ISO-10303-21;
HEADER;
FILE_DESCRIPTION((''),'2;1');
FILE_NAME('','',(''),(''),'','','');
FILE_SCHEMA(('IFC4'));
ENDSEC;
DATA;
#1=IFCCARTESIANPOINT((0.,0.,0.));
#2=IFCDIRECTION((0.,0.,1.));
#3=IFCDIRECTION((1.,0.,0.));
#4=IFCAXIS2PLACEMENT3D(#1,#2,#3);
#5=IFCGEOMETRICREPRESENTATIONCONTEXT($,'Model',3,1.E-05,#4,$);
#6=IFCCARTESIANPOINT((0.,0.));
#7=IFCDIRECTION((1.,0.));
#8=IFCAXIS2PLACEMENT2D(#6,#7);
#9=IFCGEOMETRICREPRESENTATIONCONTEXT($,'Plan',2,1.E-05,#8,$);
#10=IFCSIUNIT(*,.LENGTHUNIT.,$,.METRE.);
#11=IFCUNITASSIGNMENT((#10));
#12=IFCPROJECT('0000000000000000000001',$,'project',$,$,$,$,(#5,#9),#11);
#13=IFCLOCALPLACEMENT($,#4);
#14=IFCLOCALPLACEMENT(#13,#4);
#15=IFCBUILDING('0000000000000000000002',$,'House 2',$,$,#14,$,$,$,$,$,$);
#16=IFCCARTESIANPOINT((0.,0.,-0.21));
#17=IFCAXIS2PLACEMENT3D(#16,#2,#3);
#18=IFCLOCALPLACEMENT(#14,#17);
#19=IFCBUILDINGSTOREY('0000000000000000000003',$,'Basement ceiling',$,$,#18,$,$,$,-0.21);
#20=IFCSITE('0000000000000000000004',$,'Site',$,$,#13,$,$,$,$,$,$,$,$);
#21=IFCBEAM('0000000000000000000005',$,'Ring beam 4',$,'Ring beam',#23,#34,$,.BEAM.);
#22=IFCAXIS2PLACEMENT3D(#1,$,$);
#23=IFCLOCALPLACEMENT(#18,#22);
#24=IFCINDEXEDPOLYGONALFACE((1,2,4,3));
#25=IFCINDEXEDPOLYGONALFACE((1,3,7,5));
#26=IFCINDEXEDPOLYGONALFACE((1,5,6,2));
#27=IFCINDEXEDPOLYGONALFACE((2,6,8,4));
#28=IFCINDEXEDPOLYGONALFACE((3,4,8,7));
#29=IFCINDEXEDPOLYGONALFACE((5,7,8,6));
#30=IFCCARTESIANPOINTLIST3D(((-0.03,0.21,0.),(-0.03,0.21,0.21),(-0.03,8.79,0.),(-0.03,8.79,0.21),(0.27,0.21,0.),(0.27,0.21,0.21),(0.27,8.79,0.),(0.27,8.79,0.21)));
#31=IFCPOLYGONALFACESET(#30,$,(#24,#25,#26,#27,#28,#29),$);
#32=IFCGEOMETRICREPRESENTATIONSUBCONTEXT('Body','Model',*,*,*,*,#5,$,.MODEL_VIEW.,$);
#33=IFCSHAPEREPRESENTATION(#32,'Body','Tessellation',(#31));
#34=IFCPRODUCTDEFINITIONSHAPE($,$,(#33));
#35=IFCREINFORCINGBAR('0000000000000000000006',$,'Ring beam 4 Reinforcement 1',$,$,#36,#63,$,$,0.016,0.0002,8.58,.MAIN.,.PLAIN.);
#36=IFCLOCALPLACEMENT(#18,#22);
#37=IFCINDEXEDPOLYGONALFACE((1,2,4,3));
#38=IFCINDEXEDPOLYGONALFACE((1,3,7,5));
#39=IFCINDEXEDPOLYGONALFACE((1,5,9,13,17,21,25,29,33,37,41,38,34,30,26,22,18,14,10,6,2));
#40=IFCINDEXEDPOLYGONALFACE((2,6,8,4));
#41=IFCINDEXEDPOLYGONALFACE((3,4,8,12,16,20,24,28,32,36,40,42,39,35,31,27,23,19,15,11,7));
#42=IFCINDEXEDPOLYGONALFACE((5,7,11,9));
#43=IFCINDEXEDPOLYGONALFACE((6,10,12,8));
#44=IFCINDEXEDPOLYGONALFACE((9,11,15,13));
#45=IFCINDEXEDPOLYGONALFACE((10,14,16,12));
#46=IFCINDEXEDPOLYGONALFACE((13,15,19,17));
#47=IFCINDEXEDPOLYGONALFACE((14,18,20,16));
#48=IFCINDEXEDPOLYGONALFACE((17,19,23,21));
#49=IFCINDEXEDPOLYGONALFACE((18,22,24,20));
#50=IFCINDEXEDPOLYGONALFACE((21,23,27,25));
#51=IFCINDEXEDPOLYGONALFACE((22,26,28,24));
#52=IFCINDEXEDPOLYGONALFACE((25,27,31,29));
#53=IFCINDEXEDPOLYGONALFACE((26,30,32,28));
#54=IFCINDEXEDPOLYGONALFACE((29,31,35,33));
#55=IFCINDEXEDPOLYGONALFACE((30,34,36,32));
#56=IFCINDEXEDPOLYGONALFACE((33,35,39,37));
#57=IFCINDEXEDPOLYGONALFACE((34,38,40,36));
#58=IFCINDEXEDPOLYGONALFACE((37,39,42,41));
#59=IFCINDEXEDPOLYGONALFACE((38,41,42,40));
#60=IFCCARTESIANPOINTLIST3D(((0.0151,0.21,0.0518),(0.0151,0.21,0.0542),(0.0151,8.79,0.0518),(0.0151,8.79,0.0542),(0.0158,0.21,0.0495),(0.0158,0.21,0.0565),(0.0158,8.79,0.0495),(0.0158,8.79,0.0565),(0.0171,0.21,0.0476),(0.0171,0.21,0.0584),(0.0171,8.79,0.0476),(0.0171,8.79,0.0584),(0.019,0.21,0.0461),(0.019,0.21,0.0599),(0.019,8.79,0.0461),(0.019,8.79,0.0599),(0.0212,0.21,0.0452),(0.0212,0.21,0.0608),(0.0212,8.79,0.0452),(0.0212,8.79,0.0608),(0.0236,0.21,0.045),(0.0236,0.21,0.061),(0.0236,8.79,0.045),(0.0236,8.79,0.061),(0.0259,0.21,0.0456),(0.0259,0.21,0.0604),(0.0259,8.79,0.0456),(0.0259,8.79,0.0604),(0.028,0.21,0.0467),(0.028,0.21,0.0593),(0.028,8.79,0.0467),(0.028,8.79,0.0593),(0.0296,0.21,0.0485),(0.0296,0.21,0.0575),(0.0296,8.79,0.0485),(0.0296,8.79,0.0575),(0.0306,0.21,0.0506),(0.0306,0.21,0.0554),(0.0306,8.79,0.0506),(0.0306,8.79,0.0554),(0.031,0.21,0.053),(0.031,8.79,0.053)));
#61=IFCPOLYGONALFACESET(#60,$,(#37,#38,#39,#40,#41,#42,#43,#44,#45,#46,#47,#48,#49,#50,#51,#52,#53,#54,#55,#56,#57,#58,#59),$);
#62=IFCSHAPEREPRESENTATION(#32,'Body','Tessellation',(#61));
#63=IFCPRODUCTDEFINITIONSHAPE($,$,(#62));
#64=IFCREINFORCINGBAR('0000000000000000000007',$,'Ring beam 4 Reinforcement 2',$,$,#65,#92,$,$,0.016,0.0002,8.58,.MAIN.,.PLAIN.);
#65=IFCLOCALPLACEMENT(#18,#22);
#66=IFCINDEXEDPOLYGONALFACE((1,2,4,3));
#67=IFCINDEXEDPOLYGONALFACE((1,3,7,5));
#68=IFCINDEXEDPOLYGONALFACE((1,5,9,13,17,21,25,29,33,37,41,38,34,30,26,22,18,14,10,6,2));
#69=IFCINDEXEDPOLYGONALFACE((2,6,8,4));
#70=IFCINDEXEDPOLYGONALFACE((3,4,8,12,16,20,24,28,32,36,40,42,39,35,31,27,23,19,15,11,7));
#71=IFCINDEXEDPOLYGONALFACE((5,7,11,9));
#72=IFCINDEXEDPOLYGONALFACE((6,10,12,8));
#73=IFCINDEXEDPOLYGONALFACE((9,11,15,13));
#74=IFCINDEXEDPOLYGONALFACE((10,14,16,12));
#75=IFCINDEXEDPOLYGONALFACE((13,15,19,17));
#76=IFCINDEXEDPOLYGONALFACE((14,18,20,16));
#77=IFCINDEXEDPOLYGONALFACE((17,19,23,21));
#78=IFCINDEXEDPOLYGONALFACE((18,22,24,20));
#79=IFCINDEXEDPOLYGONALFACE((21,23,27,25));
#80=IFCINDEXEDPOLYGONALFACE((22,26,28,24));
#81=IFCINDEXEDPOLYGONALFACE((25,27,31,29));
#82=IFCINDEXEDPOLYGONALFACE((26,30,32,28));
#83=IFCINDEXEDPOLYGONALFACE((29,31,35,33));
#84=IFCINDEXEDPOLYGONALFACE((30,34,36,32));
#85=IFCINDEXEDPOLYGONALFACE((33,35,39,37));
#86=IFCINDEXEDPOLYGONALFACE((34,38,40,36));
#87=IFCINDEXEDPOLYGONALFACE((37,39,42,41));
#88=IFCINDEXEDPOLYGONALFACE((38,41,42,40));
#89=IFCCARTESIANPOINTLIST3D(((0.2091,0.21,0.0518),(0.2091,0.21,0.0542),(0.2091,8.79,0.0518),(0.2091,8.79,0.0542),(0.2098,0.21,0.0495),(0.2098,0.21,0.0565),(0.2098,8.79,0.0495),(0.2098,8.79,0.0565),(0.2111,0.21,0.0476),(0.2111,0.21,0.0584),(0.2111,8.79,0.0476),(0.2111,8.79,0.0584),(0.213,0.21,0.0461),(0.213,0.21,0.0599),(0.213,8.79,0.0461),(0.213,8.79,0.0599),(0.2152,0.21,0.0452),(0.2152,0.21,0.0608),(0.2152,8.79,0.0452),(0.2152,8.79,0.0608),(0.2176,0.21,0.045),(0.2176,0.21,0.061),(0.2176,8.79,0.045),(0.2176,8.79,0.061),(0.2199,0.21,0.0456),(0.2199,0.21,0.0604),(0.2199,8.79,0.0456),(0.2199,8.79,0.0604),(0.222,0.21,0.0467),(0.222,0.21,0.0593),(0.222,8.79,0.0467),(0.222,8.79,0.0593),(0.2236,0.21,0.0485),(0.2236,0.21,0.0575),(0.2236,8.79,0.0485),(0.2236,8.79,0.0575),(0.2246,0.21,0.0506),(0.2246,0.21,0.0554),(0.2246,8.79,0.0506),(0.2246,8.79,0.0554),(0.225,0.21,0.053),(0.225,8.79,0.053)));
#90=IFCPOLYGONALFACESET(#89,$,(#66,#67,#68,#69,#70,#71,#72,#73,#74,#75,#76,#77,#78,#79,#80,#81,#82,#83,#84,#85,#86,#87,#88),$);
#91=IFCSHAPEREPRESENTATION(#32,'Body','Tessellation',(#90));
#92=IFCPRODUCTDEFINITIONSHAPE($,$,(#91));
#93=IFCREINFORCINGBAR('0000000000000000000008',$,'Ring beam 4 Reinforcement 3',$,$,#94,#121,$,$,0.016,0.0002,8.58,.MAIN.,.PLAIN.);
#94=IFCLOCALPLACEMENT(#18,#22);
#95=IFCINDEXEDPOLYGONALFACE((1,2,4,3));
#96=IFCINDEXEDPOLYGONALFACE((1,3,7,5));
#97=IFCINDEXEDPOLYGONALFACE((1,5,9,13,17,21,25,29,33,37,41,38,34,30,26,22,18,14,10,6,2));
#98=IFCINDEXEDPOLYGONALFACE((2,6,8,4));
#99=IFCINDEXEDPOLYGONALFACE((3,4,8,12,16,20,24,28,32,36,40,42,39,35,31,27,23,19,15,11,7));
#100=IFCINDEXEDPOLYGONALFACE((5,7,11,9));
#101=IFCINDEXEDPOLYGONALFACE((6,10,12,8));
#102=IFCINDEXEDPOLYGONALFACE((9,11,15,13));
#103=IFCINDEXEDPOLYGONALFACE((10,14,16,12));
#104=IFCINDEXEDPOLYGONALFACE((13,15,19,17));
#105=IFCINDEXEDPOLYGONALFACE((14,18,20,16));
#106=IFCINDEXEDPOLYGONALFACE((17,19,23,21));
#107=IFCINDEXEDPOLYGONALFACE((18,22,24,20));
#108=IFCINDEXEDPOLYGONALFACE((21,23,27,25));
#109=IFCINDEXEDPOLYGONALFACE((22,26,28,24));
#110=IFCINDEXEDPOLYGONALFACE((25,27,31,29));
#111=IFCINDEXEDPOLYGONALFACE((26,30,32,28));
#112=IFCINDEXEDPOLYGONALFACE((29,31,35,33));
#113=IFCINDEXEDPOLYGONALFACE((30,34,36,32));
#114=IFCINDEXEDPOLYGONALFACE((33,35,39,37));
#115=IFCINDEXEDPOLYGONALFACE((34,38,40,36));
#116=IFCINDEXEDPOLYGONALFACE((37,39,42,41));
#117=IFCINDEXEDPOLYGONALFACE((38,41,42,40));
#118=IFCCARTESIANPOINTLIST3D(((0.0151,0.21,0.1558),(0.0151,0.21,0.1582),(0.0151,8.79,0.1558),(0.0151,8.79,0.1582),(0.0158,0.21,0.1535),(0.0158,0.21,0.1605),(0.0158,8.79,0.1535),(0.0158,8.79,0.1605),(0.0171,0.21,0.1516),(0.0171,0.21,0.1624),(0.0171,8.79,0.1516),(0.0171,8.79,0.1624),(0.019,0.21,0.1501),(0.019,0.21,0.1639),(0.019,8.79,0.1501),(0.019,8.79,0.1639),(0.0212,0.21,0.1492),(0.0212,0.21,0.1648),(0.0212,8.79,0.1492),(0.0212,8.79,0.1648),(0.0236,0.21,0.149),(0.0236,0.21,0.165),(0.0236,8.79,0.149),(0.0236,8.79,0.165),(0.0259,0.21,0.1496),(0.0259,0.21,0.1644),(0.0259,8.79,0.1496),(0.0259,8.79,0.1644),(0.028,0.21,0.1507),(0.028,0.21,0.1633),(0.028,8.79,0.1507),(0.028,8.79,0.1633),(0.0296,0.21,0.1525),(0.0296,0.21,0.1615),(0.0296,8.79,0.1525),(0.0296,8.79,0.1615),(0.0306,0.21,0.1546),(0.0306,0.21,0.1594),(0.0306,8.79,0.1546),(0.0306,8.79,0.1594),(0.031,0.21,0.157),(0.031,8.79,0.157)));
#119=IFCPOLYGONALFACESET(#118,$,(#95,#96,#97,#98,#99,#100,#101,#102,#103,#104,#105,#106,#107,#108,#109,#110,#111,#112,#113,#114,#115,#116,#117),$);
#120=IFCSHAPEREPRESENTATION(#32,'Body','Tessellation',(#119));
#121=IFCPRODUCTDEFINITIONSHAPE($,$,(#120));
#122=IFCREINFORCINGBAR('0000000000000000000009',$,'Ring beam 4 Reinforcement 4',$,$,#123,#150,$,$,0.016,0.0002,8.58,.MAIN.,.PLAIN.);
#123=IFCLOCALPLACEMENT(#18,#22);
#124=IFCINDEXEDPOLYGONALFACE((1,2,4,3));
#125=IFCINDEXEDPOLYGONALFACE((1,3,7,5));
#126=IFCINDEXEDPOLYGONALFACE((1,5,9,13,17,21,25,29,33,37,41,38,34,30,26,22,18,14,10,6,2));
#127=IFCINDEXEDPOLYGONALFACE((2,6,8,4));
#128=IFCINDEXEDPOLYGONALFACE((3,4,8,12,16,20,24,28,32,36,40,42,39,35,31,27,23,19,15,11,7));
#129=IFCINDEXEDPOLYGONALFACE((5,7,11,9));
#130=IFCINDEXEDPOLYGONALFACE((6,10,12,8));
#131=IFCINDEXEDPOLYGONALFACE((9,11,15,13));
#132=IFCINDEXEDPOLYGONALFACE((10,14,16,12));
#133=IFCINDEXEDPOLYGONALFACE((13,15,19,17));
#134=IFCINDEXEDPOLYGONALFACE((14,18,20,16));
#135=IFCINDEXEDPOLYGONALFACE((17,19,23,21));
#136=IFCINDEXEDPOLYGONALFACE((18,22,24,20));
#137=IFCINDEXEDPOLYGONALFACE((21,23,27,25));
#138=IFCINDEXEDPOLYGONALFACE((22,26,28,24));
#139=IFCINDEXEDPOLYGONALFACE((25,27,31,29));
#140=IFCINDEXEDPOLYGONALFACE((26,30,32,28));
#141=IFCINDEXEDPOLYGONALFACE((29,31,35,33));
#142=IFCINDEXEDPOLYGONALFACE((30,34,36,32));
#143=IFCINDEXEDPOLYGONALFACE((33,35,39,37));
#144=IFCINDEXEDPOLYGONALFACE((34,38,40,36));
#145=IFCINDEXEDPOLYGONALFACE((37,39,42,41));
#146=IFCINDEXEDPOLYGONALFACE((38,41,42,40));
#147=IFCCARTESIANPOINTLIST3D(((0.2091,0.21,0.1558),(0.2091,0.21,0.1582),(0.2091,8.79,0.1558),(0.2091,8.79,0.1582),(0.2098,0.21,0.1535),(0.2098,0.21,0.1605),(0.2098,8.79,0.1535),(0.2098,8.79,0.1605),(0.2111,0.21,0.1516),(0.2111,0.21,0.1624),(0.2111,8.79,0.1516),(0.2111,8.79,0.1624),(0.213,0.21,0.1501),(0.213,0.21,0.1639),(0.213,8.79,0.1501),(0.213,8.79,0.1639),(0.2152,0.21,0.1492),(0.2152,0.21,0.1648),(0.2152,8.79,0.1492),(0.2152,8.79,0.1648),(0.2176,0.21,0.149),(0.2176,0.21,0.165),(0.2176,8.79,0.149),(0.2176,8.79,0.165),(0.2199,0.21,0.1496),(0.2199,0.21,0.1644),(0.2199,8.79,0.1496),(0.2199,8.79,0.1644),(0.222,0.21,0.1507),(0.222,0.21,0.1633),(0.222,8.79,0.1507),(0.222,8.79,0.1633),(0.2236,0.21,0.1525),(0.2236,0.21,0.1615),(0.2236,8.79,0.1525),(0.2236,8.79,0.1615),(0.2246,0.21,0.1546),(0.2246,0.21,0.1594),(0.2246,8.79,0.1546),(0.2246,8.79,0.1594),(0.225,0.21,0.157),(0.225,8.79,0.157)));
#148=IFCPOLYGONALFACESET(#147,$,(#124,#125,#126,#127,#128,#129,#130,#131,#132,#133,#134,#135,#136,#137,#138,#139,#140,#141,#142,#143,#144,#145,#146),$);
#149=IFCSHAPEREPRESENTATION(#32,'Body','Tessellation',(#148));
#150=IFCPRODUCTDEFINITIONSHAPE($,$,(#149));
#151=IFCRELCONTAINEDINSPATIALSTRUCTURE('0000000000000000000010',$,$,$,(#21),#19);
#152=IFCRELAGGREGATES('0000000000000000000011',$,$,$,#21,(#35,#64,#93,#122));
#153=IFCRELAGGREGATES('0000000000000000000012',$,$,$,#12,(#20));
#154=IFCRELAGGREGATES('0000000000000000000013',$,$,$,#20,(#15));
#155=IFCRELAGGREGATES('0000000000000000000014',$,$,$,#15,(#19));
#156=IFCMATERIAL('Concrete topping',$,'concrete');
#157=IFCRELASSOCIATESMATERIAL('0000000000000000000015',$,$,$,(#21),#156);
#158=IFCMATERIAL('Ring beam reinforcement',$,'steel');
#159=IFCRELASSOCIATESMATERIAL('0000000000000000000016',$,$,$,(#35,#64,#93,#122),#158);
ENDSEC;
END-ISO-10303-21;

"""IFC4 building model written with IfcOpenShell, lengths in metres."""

from ifc_helpers import new_model, si_unit, frame, origin_with_axes, origin_2d, origin_2d_with_axis, place, context, subcontext, project, spatial, circle_curve, rectangle, outline, extrude, material, element, aggregate, save


model = new_model("IFC4")

# Units and contexts
model_context = context("Model", 3, precision=1e-05, world=origin_with_axes())
plan_context = context("Plan", 2, precision=1e-05, world=origin_2d_with_axis())
body_context = subcontext(model_context, "Body", "Model", "MODEL_VIEW")
ifc_project = project(units=[si_unit("LENGTHUNIT", "METRE")], contexts=[model_context, plan_context])

# Site, building, storey
site_placement = place(None, origin_with_axes())
site = spatial("IfcSite", under=ifc_project, at=site_placement, Name="Site")
building_placement = place(site_placement, origin_with_axes())
building = spatial("IfcBuilding", under=site, at=building_placement, Name="House 2")
storey_placement = place(building_placement, frame((0.0, 0.0, -0.21), z_axis=(0.0, 0.0, 1.0), x_axis=(1.0, 0.0, 0.0)))
storey = spatial("IfcBuildingStorey", under=building, at=storey_placement, Name="Basement ceiling", Elevation=-0.21)

# Beam
ifc_material_1 = material(Name="Concrete topping", Category="concrete")
beam_1_placement = place(storey_placement, frame((0.12, 8.79, 0.105), z_axis=(0.0, 0.0, 1.0), x_axis=(0.0, -1.0, 0.0)))
beam_1 = element("IfcBeam", 1, at=beam_1_placement, inside=storey, material=ifc_material_1, Name="Ring beam 4", ObjectType="Ring beam", PredefinedType="BEAM", context=body_context, shape_type="SweptSolid", body=[
    extrude(rectangle(XDim=0.3, YDim=0.21), frame((0.0, 0.0, 0.0), z_axis=(1.0, 0.0, 0.0), x_axis=(0.0, 1.0, 0.0)), (0.0, 0.0, 1.0), 8.58),
])

# Reinforcing bars
ifc_material_2 = material(Name="Ring beam reinforcement", Category="steel")
reinforcing_bar_1_placement = place(beam_1_placement, frame((0.0, -0.097, -0.052), z_axis=(0.0, 0.0, 1.0), x_axis=(1.0, 0.0, 0.0)))
reinforcing_bar_1 = element("IfcReinforcingBar", 2, at=reinforcing_bar_1_placement, material=ifc_material_2, Name="Ring beam 4 Reinforcement 1", BarLength=8.58, BarSurface="PLAIN", CrossSectionArea=0.0002, NominalDiameter=0.016, PredefinedType="MAIN", context=body_context, shape_type="SweptSolid", body=[
    extrude(outline(circle_curve(origin_2d(), 0.008)), frame((0.0, 0.0, 0.0), z_axis=(1.0, 0.0, 0.0), x_axis=(0.0, 1.0, 0.0)), (0.0, 0.0, 1.0), 8.58),
])
reinforcing_bar_2_placement = place(beam_1_placement, frame((0.0, 0.097, -0.052), z_axis=(0.0, 0.0, 1.0), x_axis=(1.0, 0.0, 0.0)))
reinforcing_bar_2 = element("IfcReinforcingBar", 3, at=reinforcing_bar_2_placement, material=ifc_material_2, Name="Ring beam 4 Reinforcement 2", BarLength=8.58, BarSurface="PLAIN", CrossSectionArea=0.0002, NominalDiameter=0.016, PredefinedType="MAIN", context=body_context, shape_type="SweptSolid", body=[
    extrude(outline(circle_curve(origin_2d(), 0.008)), frame((0.0, 0.0, 0.0), z_axis=(1.0, 0.0, 0.0), x_axis=(0.0, 1.0, 0.0)), (0.0, 0.0, 1.0), 8.58),
])
reinforcing_bar_3_placement = place(beam_1_placement, frame((0.0, -0.097, 0.052), z_axis=(0.0, 0.0, 1.0), x_axis=(1.0, 0.0, 0.0)))
reinforcing_bar_3 = element("IfcReinforcingBar", 4, at=reinforcing_bar_3_placement, material=ifc_material_2, Name="Ring beam 4 Reinforcement 3", BarLength=8.58, BarSurface="PLAIN", CrossSectionArea=0.0002, NominalDiameter=0.016, PredefinedType="MAIN", context=body_context, shape_type="SweptSolid", body=[
    extrude(outline(circle_curve(origin_2d(), 0.008)), frame((0.0, 0.0, 0.0), z_axis=(1.0, 0.0, 0.0), x_axis=(0.0, 1.0, 0.0)), (0.0, 0.0, 1.0), 8.58),
])
reinforcing_bar_4_placement = place(beam_1_placement, frame((0.0, 0.097, 0.052), z_axis=(0.0, 0.0, 1.0), x_axis=(1.0, 0.0, 0.0)))
reinforcing_bar_4 = element("IfcReinforcingBar", 5, at=reinforcing_bar_4_placement, material=ifc_material_2, Name="Ring beam 4 Reinforcement 4", BarLength=8.58, BarSurface="PLAIN", CrossSectionArea=0.0002, NominalDiameter=0.016, PredefinedType="MAIN", context=body_context, shape_type="SweptSolid", body=[
    extrude(outline(circle_curve(origin_2d(), 0.008)), frame((0.0, 0.0, 0.0), z_axis=(1.0, 0.0, 0.0), x_axis=(0.0, 1.0, 0.0)), (0.0, 0.0, 1.0), 8.58),
])
aggregate(beam_1, [reinforcing_bar_1, reinforcing_bar_2, reinforcing_bar_3, reinforcing_bar_4])

save(model, "model.ifc")
